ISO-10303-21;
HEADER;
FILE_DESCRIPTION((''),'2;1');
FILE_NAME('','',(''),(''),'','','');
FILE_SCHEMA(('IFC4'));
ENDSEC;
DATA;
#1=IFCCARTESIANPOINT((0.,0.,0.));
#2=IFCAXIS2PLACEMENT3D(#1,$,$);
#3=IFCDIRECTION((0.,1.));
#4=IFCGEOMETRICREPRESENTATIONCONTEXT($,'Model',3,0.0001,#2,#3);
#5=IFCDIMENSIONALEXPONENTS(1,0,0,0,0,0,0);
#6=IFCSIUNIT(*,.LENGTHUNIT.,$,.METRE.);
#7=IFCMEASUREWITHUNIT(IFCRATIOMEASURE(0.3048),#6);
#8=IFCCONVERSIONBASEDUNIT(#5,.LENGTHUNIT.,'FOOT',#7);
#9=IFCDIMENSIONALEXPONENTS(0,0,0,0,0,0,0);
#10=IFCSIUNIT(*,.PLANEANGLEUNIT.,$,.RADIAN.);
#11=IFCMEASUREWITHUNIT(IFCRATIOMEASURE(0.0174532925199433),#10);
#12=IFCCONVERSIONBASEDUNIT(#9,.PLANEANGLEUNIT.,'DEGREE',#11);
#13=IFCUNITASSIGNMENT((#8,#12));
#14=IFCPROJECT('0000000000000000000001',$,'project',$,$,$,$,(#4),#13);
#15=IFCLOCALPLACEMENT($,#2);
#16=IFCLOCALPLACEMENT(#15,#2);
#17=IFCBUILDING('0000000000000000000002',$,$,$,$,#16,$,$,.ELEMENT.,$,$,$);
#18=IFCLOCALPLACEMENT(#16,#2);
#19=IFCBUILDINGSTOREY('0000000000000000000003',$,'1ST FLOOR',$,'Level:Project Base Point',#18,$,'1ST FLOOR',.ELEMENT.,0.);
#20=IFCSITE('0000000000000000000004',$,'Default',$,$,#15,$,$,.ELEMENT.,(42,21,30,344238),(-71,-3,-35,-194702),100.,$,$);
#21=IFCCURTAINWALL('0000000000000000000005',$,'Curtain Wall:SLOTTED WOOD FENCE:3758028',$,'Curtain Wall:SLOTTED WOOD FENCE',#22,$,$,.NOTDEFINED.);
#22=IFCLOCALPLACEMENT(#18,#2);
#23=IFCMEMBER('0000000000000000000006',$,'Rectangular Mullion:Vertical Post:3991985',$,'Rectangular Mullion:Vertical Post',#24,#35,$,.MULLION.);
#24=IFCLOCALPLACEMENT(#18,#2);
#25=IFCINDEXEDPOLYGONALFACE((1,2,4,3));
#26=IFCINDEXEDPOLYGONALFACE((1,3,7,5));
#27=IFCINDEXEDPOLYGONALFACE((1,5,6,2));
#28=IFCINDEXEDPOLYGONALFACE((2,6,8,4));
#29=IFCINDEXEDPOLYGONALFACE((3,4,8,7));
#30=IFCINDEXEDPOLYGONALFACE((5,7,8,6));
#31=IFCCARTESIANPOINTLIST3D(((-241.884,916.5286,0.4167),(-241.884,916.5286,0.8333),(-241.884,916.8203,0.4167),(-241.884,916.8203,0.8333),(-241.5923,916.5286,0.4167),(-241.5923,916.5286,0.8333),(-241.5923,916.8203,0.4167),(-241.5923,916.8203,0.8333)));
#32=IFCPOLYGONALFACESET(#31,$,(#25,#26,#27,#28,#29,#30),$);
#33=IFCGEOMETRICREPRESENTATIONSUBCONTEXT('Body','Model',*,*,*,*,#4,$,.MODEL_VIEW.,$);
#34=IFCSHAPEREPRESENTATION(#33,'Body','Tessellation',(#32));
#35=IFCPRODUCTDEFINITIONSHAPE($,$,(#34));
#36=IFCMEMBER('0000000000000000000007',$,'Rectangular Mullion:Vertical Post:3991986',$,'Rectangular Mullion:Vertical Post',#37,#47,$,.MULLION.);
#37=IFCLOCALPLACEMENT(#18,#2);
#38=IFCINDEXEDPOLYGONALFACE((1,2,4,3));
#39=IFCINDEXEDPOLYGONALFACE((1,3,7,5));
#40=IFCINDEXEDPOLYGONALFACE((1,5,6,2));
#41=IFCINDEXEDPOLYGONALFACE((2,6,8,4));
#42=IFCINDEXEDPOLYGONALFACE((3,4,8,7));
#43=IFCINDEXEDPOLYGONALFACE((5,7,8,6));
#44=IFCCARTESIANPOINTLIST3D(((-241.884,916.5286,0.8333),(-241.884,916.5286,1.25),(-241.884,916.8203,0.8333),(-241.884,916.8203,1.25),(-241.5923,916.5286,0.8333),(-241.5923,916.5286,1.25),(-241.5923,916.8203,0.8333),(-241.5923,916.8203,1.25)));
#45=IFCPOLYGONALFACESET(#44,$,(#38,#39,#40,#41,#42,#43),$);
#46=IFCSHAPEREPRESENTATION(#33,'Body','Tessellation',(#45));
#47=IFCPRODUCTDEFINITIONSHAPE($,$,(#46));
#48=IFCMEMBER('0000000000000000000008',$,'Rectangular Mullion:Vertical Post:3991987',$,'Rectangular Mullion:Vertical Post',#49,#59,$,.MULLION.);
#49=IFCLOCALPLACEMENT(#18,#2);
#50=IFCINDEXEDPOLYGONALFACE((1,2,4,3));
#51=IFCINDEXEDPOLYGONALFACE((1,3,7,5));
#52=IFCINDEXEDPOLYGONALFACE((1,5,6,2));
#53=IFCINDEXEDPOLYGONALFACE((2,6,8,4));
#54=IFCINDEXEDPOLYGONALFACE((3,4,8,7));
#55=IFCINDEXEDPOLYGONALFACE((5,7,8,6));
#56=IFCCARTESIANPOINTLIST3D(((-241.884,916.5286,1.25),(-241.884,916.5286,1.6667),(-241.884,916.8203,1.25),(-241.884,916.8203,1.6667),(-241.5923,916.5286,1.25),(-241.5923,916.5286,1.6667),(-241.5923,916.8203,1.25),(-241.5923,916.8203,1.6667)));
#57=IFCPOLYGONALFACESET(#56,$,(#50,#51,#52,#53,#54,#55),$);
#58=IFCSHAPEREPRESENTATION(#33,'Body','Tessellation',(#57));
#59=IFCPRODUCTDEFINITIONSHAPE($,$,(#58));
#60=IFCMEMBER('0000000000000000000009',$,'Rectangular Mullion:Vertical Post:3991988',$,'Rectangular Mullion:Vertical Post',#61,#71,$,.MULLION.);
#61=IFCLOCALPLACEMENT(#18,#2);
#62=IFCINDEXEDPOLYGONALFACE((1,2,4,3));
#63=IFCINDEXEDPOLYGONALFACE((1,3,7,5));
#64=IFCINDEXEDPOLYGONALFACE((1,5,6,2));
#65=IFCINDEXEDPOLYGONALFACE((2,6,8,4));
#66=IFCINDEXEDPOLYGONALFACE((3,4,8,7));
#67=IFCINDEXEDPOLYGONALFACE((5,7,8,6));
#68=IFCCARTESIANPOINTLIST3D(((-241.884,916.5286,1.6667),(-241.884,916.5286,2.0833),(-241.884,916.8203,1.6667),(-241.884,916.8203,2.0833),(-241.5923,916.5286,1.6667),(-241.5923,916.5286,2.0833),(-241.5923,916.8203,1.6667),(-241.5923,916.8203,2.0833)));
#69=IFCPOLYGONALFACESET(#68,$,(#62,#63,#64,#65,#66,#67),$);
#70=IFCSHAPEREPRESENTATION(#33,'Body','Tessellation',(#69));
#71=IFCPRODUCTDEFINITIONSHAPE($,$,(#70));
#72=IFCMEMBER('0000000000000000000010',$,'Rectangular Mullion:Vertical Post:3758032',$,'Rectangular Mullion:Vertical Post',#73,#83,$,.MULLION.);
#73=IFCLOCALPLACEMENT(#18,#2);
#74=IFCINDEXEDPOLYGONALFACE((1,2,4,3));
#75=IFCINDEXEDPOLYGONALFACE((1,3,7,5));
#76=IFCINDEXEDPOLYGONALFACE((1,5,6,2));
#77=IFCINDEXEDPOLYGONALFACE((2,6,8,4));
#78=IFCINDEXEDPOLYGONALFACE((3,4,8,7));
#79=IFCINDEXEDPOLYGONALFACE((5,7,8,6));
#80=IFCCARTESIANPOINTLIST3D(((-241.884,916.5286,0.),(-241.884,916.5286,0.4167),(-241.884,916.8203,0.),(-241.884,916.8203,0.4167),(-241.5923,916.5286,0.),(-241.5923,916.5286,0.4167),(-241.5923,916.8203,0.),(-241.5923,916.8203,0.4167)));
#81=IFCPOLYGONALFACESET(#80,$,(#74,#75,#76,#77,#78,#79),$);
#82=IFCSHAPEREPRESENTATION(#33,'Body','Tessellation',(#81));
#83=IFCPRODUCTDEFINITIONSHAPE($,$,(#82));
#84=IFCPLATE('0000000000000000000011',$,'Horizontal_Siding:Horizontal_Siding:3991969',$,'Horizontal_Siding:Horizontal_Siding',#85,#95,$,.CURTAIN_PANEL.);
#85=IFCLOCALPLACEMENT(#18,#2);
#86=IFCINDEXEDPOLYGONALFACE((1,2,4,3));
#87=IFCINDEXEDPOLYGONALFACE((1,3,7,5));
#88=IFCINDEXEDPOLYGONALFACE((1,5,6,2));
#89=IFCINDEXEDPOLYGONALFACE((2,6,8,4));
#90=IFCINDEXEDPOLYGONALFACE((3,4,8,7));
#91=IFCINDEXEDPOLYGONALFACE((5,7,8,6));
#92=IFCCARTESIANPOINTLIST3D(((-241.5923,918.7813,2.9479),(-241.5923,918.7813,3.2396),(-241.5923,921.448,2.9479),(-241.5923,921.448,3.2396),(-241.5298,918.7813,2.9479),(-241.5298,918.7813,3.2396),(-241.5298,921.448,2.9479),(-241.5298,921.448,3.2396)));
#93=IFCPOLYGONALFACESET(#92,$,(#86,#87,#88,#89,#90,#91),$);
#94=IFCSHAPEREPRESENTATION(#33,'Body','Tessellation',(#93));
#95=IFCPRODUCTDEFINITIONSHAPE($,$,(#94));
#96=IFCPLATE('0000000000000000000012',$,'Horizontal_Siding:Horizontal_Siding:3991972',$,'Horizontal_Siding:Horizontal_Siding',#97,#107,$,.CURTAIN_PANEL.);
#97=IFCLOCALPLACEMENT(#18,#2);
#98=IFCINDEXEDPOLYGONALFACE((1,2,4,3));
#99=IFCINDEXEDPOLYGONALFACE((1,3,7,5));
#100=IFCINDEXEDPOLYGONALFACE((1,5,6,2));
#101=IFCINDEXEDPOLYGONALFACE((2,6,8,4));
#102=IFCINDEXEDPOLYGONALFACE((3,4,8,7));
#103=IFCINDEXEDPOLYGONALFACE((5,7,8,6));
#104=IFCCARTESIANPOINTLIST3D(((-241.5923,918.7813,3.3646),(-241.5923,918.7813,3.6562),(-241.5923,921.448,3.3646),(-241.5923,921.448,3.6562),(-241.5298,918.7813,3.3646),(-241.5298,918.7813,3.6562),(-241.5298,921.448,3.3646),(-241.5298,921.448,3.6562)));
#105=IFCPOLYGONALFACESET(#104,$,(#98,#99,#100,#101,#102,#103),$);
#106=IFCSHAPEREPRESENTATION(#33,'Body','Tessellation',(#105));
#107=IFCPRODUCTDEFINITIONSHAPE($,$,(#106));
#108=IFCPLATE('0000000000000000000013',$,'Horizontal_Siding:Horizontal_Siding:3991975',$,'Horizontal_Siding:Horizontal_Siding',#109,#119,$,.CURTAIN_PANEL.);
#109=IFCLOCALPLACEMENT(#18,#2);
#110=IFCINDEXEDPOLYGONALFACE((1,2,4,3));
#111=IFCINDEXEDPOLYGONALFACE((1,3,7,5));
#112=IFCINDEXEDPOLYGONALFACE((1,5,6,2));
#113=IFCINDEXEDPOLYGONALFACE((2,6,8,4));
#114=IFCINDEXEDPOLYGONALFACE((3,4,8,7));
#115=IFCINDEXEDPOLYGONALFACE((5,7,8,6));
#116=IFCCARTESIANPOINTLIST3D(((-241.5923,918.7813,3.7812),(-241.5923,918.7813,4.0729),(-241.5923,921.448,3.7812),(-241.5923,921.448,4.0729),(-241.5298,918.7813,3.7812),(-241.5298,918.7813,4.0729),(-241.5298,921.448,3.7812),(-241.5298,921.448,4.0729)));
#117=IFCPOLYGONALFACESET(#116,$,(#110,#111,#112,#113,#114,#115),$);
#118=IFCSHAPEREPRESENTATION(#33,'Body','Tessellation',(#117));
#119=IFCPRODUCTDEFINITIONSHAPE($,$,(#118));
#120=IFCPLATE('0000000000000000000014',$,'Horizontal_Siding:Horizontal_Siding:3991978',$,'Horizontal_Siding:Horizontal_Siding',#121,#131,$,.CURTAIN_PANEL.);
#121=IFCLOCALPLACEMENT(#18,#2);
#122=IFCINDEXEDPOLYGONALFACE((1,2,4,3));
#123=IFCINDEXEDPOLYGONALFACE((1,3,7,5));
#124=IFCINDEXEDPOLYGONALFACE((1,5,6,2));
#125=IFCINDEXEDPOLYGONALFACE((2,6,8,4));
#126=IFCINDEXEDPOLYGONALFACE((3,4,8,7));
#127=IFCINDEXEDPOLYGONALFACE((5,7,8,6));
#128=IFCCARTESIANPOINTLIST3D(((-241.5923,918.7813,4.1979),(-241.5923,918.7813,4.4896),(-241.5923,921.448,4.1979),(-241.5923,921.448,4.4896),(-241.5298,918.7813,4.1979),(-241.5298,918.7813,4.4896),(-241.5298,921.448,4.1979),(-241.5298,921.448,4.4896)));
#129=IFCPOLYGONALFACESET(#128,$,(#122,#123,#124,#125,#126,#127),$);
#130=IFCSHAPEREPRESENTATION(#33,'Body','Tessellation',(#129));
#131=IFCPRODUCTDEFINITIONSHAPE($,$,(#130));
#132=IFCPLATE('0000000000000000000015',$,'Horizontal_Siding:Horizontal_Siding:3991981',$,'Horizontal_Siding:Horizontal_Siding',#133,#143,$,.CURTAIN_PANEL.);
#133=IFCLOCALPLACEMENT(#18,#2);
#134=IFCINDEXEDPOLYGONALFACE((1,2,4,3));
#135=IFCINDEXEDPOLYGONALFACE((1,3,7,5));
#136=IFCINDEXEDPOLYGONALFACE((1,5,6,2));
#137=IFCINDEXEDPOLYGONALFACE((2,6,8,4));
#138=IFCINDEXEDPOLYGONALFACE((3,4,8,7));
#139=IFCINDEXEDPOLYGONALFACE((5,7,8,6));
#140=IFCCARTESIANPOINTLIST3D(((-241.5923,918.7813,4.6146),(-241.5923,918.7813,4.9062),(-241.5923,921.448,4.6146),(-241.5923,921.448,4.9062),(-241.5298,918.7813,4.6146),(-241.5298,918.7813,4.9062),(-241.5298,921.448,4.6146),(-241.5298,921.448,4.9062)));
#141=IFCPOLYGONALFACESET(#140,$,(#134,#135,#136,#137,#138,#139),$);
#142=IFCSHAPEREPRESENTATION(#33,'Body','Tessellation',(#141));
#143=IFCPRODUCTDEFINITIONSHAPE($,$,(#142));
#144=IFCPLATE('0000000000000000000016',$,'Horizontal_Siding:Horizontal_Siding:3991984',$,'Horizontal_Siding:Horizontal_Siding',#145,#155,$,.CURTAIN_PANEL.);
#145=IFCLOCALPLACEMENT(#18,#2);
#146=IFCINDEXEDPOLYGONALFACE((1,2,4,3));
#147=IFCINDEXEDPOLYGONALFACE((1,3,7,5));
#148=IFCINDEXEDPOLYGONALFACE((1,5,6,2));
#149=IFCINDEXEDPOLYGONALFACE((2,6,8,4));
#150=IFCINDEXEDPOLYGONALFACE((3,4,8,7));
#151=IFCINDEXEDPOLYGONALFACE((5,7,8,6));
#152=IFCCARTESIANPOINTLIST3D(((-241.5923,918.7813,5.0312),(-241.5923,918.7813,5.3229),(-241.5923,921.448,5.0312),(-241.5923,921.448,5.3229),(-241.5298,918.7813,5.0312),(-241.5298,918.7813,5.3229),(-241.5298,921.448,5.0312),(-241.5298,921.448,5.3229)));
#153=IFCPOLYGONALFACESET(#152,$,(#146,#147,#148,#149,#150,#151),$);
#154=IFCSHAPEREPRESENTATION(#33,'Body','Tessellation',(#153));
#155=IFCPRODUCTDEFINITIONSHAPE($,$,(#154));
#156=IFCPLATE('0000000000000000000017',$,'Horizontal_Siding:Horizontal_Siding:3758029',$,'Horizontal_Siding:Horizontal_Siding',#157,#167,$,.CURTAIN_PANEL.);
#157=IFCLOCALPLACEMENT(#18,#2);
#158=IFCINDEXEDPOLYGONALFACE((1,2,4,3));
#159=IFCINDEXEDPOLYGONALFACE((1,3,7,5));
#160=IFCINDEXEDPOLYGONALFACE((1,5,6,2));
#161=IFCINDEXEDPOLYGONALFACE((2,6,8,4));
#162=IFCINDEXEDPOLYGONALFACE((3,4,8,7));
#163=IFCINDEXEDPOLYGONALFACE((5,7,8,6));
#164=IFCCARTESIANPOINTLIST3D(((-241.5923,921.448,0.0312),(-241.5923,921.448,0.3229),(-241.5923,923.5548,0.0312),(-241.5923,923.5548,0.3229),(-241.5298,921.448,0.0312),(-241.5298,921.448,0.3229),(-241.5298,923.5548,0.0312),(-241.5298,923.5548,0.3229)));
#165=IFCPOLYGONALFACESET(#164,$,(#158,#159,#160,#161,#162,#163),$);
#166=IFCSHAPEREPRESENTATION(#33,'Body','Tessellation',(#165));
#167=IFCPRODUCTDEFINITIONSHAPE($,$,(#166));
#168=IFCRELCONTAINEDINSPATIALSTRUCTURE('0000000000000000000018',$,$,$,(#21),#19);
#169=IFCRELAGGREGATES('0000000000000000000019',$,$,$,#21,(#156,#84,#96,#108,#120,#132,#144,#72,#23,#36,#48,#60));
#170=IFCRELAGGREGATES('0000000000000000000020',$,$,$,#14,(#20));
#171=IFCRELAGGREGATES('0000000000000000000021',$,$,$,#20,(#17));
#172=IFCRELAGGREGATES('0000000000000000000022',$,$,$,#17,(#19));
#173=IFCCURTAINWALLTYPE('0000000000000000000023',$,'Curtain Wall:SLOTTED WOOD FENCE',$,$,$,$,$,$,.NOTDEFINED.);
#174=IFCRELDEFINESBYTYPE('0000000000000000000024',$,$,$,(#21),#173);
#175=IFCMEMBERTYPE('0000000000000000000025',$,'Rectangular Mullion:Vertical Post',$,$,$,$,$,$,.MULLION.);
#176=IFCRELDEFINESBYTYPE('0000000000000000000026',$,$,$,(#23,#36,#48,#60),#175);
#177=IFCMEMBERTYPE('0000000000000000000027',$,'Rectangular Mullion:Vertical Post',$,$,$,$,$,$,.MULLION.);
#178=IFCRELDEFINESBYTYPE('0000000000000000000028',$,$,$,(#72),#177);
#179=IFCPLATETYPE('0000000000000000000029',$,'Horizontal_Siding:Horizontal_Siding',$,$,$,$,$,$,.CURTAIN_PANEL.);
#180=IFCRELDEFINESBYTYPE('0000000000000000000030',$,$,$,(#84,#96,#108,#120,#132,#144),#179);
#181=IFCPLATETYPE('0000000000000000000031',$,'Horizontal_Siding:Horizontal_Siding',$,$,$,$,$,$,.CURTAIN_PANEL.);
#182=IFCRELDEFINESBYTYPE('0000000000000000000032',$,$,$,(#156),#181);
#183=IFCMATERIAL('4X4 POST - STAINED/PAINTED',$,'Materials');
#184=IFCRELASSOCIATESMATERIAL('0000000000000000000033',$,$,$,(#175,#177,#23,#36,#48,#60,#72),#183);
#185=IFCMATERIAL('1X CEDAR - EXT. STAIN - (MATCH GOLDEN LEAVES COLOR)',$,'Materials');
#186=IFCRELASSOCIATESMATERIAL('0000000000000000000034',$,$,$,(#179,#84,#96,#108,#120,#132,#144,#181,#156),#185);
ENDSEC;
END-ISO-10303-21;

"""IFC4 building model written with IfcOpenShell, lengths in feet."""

from ifc_helpers import new_model, entity, si_unit, converted_unit, direction, frame, frame_2d, origin, origin_2d_with_axis, place, context, subcontext, project, spatial, rectangle, extrude, source, transform, mapped, material, material_profile, profile_set, profile_usage, type_object, type_shapes, element, aggregate, save


model = new_model("IFC4")

# Units and contexts
model_context = context("Model", 3, precision=0.0001, world=origin(), true_north=direction((0.0, 1.0)))
body_context = subcontext(model_context, "Body", "Model", "MODEL_VIEW")
ifc_project = project(units=[converted_unit("LENGTHUNIT", "FOOT", entity("IfcRatioMeasure", 0.3048), si_unit("LENGTHUNIT", "METRE"), dimensions=[1, 0, 0, 0, 0, 0, 0]), converted_unit("PLANEANGLEUNIT", "DEGREE", entity("IfcRatioMeasure", 0.0174532925199433), si_unit("PLANEANGLEUNIT", "RADIAN"), dimensions=[0, 0, 0, 0, 0, 0, 0])], contexts=[model_context])

# Site, building, storey
site_placement = place(None, origin())
site = spatial("IfcSite", under=ifc_project, at=site_placement, Name="Default", CompositionType="ELEMENT", RefLatitude=(42, 21, 30, 344238), RefLongitude=(-71, -3, -35, -194702), RefElevation=100.0)
building_placement = place(site_placement, origin())
building = spatial("IfcBuilding", under=site, at=building_placement, CompositionType="ELEMENT")
storey_placement = place(building_placement, origin())
storey = spatial("IfcBuildingStorey", under=building, at=storey_placement, Name="1ST FLOOR", ObjectType="Level:Project Base Point", LongName="1ST FLOOR", CompositionType="ELEMENT", Elevation=0.0)

# Curtain wall, members, plates
curtain_wall_type = type_object("IfcCurtainWallType", Name="Curtain Wall:SLOTTED WOOD FENCE", PredefinedType="NOTDEFINED")
curtain_wall_placement = place(storey_placement, origin())
curtain_wall = element("IfcCurtainWall", 1, at=curtain_wall_placement, inside=storey, type_object=curtain_wall_type, Name="Curtain Wall:SLOTTED WOOD FENCE:3758028", ObjectType="Curtain Wall:SLOTTED WOOD FENCE", PredefinedType="NOTDEFINED")
ifc_material_1 = material(Name="4X4 POST - STAINED/PAINTED", Category="Materials")
ifc_material_profile = material_profile(ifc_material_1, rectangle(XDim=0.2917, YDim=0.2917, at=origin_2d_with_axis()), Name="Vertical Post")
ifc_profile_set = profile_set([ifc_material_profile], Name="Vertical Post")
ifc_profile_usage_1 = profile_usage(ifc_profile_set)
member_type_1 = type_object("IfcMemberType", Name="Rectangular Mullion:Vertical Post", PredefinedType="MULLION", material=ifc_profile_set)
shared_shape_1 = source(origin(), body_context, "Body", "SweptSolid", [
    extrude(rectangle(XDim=0.2917, YDim=0.2917, at=frame_2d((0.0, 0.0), x_axis=(1.0, 0.0))), frame((-0.1458, 0.2083, -0.4167), z_axis=(0.0, 0.0, 1.0), x_axis=(0.0, -1.0, 0.0)), (0.0, 0.0, 1.0), 0.4167),
])
type_shapes(member_type_1, [shared_shape_1])
member_1_placement = place(storey_placement, frame((-241.5298, 916.5286, 0.4167), z_axis=(0.0, 0.0, -1.0), x_axis=(0.0, -1.0, 0.0)))
member_1 = element("IfcMember", 2, at=member_1_placement, type_object=member_type_1, material=ifc_profile_usage_1, Name="Rectangular Mullion:Vertical Post:3991985", ObjectType="Rectangular Mullion:Vertical Post", PredefinedType="MULLION", context=body_context, shape_type="MappedRepresentation", body=[
    mapped(shared_shape_1, transform((0.0, 0.0, 0.0), scale=1.0)),
])
ifc_profile_usage_2 = profile_usage(ifc_profile_set)
member_2_placement = place(storey_placement, frame((-241.5298, 916.5286, 0.8333), z_axis=(0.0, 0.0, -1.0), x_axis=(0.0, -1.0, 0.0)))
member_2 = element("IfcMember", 3, at=member_2_placement, type_object=member_type_1, material=ifc_profile_usage_2, Name="Rectangular Mullion:Vertical Post:3991986", ObjectType="Rectangular Mullion:Vertical Post", PredefinedType="MULLION", context=body_context, shape_type="MappedRepresentation", body=[
    mapped(shared_shape_1, transform((0.0, 0.0, 0.0), scale=1.0)),
])
ifc_profile_usage_3 = profile_usage(ifc_profile_set)
member_3_placement = place(storey_placement, frame((-241.5298, 916.5286, 1.25), z_axis=(0.0, 0.0, -1.0), x_axis=(0.0, -1.0, 0.0)))
member_3 = element("IfcMember", 4, at=member_3_placement, type_object=member_type_1, material=ifc_profile_usage_3, Name="Rectangular Mullion:Vertical Post:3991987", ObjectType="Rectangular Mullion:Vertical Post", PredefinedType="MULLION", context=body_context, shape_type="MappedRepresentation", body=[
    mapped(shared_shape_1, transform((0.0, 0.0, 0.0), scale=1.0)),
])
ifc_profile_usage_4 = profile_usage(ifc_profile_set)
member_4_placement = place(storey_placement, frame((-241.5298, 916.5286, 1.6667), z_axis=(0.0, 0.0, -1.0), x_axis=(0.0, -1.0, 0.0)))
member_4 = element("IfcMember", 5, at=member_4_placement, type_object=member_type_1, material=ifc_profile_usage_4, Name="Rectangular Mullion:Vertical Post:3991988", ObjectType="Rectangular Mullion:Vertical Post", PredefinedType="MULLION", context=body_context, shape_type="MappedRepresentation", body=[
    mapped(shared_shape_1, transform((0.0, 0.0, 0.0), scale=1.0)),
])
ifc_profile_usage_5 = profile_usage(ifc_profile_set)
member_type_2 = type_object("IfcMemberType", Name="Rectangular Mullion:Vertical Post", PredefinedType="MULLION", material=ifc_profile_set)
shared_shape_2 = source(origin(), body_context, "Body", "SweptSolid", [
    extrude(rectangle(XDim=0.2917, YDim=0.2917, at=frame_2d((0.0, 0.0), x_axis=(1.0, 0.0))), frame((-0.1458, 0.2083, -0.4167), z_axis=(0.0, 0.0, 1.0), x_axis=(0.0, -1.0, 0.0)), (0.0, 0.0, 1.0), 0.4167),
])
type_shapes(member_type_2, [shared_shape_2])
placement = place(building_placement, frame((0.0, 0.0, 10.8021)))
member_5_placement = place(placement, frame((-241.5298, 916.5286, -10.8021), z_axis=(0.0, 0.0, -1.0), x_axis=(0.0, -1.0, 0.0)))
member_5 = element("IfcMember", 6, at=member_5_placement, type_object=member_type_2, material=ifc_profile_usage_5, Name="Rectangular Mullion:Vertical Post:3758032", ObjectType="Rectangular Mullion:Vertical Post", PredefinedType="MULLION", context=body_context, shape_type="MappedRepresentation", body=[
    mapped(shared_shape_2, transform((0.0, 0.0, 0.0), scale=1.0)),
])
ifc_material_2 = material(Name="1X CEDAR - EXT. STAIN - (MATCH GOLDEN LEAVES COLOR)", Category="Materials")
plate_type_1 = type_object("IfcPlateType", Name="Horizontal_Siding:Horizontal_Siding", PredefinedType="CURTAIN_PANEL", material=ifc_material_2)
shared_shape_3 = source(origin(), body_context, "Body", "SweptSolid", [
    extrude(rectangle(XDim=0.0625, YDim=2.6667, at=origin_2d_with_axis()), frame((1.3333, 0.0312, 0.0), z_axis=(0.0, 0.0, 1.0), x_axis=(0.0, 1.0, 0.0)), (0.0, 0.0, 1.0), 0.2917),
])
type_shapes(plate_type_1, [shared_shape_3])
plate_1_placement = place(curtain_wall_placement, frame((-241.5923, 921.448, 2.9479), z_axis=(0.0, 0.0, 1.0), x_axis=(0.0, -1.0, 0.0)))
plate_1 = element("IfcPlate", 7, at=plate_1_placement, type_object=plate_type_1, material=ifc_material_2, Name="Horizontal_Siding:Horizontal_Siding:3991969", ObjectType="Horizontal_Siding:Horizontal_Siding", PredefinedType="CURTAIN_PANEL", context=body_context, shape_type="MappedRepresentation", body=[
    mapped(shared_shape_3, transform((0.0, 0.0, 0.0), scale=1.0)),
])
plate_2_placement = place(curtain_wall_placement, frame((-241.5923, 921.448, 3.3646), z_axis=(0.0, 0.0, 1.0), x_axis=(0.0, -1.0, 0.0)))
plate_2 = element("IfcPlate", 8, at=plate_2_placement, type_object=plate_type_1, material=ifc_material_2, Name="Horizontal_Siding:Horizontal_Siding:3991972", ObjectType="Horizontal_Siding:Horizontal_Siding", PredefinedType="CURTAIN_PANEL", context=body_context, shape_type="MappedRepresentation", body=[
    mapped(shared_shape_3, transform((0.0, 0.0, 0.0), scale=1.0)),
])
plate_3_placement = place(curtain_wall_placement, frame((-241.5923, 921.448, 3.7812), z_axis=(0.0, 0.0, 1.0), x_axis=(0.0, -1.0, 0.0)))
plate_3 = element("IfcPlate", 9, at=plate_3_placement, type_object=plate_type_1, material=ifc_material_2, Name="Horizontal_Siding:Horizontal_Siding:3991975", ObjectType="Horizontal_Siding:Horizontal_Siding", PredefinedType="CURTAIN_PANEL", context=body_context, shape_type="MappedRepresentation", body=[
    mapped(shared_shape_3, transform((0.0, 0.0, 0.0), scale=1.0)),
])
plate_4_placement = place(curtain_wall_placement, frame((-241.5923, 921.448, 4.1979), z_axis=(0.0, 0.0, 1.0), x_axis=(0.0, -1.0, 0.0)))
plate_4 = element("IfcPlate", 10, at=plate_4_placement, type_object=plate_type_1, material=ifc_material_2, Name="Horizontal_Siding:Horizontal_Siding:3991978", ObjectType="Horizontal_Siding:Horizontal_Siding", PredefinedType="CURTAIN_PANEL", context=body_context, shape_type="MappedRepresentation", body=[
    mapped(shared_shape_3, transform((0.0, 0.0, 0.0), scale=1.0)),
])
plate_5_placement = place(curtain_wall_placement, frame((-241.5923, 921.448, 4.6146), z_axis=(0.0, 0.0, 1.0), x_axis=(0.0, -1.0, 0.0)))
plate_5 = element("IfcPlate", 11, at=plate_5_placement, type_object=plate_type_1, material=ifc_material_2, Name="Horizontal_Siding:Horizontal_Siding:3991981", ObjectType="Horizontal_Siding:Horizontal_Siding", PredefinedType="CURTAIN_PANEL", context=body_context, shape_type="MappedRepresentation", body=[
    mapped(shared_shape_3, transform((0.0, 0.0, 0.0), scale=1.0)),
])
plate_6_placement = place(curtain_wall_placement, frame((-241.5923, 921.448, 5.0312), z_axis=(0.0, 0.0, 1.0), x_axis=(0.0, -1.0, 0.0)))
plate_6 = element("IfcPlate", 12, at=plate_6_placement, type_object=plate_type_1, material=ifc_material_2, Name="Horizontal_Siding:Horizontal_Siding:3991984", ObjectType="Horizontal_Siding:Horizontal_Siding", PredefinedType="CURTAIN_PANEL", context=body_context, shape_type="MappedRepresentation", body=[
    mapped(shared_shape_3, transform((0.0, 0.0, 0.0), scale=1.0)),
])
plate_type_2 = type_object("IfcPlateType", Name="Horizontal_Siding:Horizontal_Siding", PredefinedType="CURTAIN_PANEL", material=ifc_material_2)
shared_shape_4 = source(origin(), body_context, "Body", "SweptSolid", [
    extrude(rectangle(XDim=0.0625, YDim=2.1069, at=origin_2d_with_axis()), frame((1.0534, 0.0312, 0.0), z_axis=(0.0, 0.0, 1.0), x_axis=(0.0, 1.0, 0.0)), (0.0, 0.0, 1.0), 0.2917),
])
type_shapes(plate_type_2, [shared_shape_4])
plate_7_placement = place(curtain_wall_placement, frame((-241.5923, 923.5548, 0.0312), z_axis=(0.0, 0.0, 1.0), x_axis=(0.0, -1.0, 0.0)))
plate_7 = element("IfcPlate", 13, at=plate_7_placement, type_object=plate_type_2, material=ifc_material_2, Name="Horizontal_Siding:Horizontal_Siding:3758029", ObjectType="Horizontal_Siding:Horizontal_Siding", PredefinedType="CURTAIN_PANEL", context=body_context, shape_type="MappedRepresentation", body=[
    mapped(shared_shape_4, transform((0.0, 0.0, 0.0), scale=1.0)),
])
aggregate(curtain_wall, [plate_7, plate_1, plate_2, plate_3, plate_4, plate_5, plate_6, member_5, member_1, member_2, member_3, member_4])

save(model, "model.ifc")
